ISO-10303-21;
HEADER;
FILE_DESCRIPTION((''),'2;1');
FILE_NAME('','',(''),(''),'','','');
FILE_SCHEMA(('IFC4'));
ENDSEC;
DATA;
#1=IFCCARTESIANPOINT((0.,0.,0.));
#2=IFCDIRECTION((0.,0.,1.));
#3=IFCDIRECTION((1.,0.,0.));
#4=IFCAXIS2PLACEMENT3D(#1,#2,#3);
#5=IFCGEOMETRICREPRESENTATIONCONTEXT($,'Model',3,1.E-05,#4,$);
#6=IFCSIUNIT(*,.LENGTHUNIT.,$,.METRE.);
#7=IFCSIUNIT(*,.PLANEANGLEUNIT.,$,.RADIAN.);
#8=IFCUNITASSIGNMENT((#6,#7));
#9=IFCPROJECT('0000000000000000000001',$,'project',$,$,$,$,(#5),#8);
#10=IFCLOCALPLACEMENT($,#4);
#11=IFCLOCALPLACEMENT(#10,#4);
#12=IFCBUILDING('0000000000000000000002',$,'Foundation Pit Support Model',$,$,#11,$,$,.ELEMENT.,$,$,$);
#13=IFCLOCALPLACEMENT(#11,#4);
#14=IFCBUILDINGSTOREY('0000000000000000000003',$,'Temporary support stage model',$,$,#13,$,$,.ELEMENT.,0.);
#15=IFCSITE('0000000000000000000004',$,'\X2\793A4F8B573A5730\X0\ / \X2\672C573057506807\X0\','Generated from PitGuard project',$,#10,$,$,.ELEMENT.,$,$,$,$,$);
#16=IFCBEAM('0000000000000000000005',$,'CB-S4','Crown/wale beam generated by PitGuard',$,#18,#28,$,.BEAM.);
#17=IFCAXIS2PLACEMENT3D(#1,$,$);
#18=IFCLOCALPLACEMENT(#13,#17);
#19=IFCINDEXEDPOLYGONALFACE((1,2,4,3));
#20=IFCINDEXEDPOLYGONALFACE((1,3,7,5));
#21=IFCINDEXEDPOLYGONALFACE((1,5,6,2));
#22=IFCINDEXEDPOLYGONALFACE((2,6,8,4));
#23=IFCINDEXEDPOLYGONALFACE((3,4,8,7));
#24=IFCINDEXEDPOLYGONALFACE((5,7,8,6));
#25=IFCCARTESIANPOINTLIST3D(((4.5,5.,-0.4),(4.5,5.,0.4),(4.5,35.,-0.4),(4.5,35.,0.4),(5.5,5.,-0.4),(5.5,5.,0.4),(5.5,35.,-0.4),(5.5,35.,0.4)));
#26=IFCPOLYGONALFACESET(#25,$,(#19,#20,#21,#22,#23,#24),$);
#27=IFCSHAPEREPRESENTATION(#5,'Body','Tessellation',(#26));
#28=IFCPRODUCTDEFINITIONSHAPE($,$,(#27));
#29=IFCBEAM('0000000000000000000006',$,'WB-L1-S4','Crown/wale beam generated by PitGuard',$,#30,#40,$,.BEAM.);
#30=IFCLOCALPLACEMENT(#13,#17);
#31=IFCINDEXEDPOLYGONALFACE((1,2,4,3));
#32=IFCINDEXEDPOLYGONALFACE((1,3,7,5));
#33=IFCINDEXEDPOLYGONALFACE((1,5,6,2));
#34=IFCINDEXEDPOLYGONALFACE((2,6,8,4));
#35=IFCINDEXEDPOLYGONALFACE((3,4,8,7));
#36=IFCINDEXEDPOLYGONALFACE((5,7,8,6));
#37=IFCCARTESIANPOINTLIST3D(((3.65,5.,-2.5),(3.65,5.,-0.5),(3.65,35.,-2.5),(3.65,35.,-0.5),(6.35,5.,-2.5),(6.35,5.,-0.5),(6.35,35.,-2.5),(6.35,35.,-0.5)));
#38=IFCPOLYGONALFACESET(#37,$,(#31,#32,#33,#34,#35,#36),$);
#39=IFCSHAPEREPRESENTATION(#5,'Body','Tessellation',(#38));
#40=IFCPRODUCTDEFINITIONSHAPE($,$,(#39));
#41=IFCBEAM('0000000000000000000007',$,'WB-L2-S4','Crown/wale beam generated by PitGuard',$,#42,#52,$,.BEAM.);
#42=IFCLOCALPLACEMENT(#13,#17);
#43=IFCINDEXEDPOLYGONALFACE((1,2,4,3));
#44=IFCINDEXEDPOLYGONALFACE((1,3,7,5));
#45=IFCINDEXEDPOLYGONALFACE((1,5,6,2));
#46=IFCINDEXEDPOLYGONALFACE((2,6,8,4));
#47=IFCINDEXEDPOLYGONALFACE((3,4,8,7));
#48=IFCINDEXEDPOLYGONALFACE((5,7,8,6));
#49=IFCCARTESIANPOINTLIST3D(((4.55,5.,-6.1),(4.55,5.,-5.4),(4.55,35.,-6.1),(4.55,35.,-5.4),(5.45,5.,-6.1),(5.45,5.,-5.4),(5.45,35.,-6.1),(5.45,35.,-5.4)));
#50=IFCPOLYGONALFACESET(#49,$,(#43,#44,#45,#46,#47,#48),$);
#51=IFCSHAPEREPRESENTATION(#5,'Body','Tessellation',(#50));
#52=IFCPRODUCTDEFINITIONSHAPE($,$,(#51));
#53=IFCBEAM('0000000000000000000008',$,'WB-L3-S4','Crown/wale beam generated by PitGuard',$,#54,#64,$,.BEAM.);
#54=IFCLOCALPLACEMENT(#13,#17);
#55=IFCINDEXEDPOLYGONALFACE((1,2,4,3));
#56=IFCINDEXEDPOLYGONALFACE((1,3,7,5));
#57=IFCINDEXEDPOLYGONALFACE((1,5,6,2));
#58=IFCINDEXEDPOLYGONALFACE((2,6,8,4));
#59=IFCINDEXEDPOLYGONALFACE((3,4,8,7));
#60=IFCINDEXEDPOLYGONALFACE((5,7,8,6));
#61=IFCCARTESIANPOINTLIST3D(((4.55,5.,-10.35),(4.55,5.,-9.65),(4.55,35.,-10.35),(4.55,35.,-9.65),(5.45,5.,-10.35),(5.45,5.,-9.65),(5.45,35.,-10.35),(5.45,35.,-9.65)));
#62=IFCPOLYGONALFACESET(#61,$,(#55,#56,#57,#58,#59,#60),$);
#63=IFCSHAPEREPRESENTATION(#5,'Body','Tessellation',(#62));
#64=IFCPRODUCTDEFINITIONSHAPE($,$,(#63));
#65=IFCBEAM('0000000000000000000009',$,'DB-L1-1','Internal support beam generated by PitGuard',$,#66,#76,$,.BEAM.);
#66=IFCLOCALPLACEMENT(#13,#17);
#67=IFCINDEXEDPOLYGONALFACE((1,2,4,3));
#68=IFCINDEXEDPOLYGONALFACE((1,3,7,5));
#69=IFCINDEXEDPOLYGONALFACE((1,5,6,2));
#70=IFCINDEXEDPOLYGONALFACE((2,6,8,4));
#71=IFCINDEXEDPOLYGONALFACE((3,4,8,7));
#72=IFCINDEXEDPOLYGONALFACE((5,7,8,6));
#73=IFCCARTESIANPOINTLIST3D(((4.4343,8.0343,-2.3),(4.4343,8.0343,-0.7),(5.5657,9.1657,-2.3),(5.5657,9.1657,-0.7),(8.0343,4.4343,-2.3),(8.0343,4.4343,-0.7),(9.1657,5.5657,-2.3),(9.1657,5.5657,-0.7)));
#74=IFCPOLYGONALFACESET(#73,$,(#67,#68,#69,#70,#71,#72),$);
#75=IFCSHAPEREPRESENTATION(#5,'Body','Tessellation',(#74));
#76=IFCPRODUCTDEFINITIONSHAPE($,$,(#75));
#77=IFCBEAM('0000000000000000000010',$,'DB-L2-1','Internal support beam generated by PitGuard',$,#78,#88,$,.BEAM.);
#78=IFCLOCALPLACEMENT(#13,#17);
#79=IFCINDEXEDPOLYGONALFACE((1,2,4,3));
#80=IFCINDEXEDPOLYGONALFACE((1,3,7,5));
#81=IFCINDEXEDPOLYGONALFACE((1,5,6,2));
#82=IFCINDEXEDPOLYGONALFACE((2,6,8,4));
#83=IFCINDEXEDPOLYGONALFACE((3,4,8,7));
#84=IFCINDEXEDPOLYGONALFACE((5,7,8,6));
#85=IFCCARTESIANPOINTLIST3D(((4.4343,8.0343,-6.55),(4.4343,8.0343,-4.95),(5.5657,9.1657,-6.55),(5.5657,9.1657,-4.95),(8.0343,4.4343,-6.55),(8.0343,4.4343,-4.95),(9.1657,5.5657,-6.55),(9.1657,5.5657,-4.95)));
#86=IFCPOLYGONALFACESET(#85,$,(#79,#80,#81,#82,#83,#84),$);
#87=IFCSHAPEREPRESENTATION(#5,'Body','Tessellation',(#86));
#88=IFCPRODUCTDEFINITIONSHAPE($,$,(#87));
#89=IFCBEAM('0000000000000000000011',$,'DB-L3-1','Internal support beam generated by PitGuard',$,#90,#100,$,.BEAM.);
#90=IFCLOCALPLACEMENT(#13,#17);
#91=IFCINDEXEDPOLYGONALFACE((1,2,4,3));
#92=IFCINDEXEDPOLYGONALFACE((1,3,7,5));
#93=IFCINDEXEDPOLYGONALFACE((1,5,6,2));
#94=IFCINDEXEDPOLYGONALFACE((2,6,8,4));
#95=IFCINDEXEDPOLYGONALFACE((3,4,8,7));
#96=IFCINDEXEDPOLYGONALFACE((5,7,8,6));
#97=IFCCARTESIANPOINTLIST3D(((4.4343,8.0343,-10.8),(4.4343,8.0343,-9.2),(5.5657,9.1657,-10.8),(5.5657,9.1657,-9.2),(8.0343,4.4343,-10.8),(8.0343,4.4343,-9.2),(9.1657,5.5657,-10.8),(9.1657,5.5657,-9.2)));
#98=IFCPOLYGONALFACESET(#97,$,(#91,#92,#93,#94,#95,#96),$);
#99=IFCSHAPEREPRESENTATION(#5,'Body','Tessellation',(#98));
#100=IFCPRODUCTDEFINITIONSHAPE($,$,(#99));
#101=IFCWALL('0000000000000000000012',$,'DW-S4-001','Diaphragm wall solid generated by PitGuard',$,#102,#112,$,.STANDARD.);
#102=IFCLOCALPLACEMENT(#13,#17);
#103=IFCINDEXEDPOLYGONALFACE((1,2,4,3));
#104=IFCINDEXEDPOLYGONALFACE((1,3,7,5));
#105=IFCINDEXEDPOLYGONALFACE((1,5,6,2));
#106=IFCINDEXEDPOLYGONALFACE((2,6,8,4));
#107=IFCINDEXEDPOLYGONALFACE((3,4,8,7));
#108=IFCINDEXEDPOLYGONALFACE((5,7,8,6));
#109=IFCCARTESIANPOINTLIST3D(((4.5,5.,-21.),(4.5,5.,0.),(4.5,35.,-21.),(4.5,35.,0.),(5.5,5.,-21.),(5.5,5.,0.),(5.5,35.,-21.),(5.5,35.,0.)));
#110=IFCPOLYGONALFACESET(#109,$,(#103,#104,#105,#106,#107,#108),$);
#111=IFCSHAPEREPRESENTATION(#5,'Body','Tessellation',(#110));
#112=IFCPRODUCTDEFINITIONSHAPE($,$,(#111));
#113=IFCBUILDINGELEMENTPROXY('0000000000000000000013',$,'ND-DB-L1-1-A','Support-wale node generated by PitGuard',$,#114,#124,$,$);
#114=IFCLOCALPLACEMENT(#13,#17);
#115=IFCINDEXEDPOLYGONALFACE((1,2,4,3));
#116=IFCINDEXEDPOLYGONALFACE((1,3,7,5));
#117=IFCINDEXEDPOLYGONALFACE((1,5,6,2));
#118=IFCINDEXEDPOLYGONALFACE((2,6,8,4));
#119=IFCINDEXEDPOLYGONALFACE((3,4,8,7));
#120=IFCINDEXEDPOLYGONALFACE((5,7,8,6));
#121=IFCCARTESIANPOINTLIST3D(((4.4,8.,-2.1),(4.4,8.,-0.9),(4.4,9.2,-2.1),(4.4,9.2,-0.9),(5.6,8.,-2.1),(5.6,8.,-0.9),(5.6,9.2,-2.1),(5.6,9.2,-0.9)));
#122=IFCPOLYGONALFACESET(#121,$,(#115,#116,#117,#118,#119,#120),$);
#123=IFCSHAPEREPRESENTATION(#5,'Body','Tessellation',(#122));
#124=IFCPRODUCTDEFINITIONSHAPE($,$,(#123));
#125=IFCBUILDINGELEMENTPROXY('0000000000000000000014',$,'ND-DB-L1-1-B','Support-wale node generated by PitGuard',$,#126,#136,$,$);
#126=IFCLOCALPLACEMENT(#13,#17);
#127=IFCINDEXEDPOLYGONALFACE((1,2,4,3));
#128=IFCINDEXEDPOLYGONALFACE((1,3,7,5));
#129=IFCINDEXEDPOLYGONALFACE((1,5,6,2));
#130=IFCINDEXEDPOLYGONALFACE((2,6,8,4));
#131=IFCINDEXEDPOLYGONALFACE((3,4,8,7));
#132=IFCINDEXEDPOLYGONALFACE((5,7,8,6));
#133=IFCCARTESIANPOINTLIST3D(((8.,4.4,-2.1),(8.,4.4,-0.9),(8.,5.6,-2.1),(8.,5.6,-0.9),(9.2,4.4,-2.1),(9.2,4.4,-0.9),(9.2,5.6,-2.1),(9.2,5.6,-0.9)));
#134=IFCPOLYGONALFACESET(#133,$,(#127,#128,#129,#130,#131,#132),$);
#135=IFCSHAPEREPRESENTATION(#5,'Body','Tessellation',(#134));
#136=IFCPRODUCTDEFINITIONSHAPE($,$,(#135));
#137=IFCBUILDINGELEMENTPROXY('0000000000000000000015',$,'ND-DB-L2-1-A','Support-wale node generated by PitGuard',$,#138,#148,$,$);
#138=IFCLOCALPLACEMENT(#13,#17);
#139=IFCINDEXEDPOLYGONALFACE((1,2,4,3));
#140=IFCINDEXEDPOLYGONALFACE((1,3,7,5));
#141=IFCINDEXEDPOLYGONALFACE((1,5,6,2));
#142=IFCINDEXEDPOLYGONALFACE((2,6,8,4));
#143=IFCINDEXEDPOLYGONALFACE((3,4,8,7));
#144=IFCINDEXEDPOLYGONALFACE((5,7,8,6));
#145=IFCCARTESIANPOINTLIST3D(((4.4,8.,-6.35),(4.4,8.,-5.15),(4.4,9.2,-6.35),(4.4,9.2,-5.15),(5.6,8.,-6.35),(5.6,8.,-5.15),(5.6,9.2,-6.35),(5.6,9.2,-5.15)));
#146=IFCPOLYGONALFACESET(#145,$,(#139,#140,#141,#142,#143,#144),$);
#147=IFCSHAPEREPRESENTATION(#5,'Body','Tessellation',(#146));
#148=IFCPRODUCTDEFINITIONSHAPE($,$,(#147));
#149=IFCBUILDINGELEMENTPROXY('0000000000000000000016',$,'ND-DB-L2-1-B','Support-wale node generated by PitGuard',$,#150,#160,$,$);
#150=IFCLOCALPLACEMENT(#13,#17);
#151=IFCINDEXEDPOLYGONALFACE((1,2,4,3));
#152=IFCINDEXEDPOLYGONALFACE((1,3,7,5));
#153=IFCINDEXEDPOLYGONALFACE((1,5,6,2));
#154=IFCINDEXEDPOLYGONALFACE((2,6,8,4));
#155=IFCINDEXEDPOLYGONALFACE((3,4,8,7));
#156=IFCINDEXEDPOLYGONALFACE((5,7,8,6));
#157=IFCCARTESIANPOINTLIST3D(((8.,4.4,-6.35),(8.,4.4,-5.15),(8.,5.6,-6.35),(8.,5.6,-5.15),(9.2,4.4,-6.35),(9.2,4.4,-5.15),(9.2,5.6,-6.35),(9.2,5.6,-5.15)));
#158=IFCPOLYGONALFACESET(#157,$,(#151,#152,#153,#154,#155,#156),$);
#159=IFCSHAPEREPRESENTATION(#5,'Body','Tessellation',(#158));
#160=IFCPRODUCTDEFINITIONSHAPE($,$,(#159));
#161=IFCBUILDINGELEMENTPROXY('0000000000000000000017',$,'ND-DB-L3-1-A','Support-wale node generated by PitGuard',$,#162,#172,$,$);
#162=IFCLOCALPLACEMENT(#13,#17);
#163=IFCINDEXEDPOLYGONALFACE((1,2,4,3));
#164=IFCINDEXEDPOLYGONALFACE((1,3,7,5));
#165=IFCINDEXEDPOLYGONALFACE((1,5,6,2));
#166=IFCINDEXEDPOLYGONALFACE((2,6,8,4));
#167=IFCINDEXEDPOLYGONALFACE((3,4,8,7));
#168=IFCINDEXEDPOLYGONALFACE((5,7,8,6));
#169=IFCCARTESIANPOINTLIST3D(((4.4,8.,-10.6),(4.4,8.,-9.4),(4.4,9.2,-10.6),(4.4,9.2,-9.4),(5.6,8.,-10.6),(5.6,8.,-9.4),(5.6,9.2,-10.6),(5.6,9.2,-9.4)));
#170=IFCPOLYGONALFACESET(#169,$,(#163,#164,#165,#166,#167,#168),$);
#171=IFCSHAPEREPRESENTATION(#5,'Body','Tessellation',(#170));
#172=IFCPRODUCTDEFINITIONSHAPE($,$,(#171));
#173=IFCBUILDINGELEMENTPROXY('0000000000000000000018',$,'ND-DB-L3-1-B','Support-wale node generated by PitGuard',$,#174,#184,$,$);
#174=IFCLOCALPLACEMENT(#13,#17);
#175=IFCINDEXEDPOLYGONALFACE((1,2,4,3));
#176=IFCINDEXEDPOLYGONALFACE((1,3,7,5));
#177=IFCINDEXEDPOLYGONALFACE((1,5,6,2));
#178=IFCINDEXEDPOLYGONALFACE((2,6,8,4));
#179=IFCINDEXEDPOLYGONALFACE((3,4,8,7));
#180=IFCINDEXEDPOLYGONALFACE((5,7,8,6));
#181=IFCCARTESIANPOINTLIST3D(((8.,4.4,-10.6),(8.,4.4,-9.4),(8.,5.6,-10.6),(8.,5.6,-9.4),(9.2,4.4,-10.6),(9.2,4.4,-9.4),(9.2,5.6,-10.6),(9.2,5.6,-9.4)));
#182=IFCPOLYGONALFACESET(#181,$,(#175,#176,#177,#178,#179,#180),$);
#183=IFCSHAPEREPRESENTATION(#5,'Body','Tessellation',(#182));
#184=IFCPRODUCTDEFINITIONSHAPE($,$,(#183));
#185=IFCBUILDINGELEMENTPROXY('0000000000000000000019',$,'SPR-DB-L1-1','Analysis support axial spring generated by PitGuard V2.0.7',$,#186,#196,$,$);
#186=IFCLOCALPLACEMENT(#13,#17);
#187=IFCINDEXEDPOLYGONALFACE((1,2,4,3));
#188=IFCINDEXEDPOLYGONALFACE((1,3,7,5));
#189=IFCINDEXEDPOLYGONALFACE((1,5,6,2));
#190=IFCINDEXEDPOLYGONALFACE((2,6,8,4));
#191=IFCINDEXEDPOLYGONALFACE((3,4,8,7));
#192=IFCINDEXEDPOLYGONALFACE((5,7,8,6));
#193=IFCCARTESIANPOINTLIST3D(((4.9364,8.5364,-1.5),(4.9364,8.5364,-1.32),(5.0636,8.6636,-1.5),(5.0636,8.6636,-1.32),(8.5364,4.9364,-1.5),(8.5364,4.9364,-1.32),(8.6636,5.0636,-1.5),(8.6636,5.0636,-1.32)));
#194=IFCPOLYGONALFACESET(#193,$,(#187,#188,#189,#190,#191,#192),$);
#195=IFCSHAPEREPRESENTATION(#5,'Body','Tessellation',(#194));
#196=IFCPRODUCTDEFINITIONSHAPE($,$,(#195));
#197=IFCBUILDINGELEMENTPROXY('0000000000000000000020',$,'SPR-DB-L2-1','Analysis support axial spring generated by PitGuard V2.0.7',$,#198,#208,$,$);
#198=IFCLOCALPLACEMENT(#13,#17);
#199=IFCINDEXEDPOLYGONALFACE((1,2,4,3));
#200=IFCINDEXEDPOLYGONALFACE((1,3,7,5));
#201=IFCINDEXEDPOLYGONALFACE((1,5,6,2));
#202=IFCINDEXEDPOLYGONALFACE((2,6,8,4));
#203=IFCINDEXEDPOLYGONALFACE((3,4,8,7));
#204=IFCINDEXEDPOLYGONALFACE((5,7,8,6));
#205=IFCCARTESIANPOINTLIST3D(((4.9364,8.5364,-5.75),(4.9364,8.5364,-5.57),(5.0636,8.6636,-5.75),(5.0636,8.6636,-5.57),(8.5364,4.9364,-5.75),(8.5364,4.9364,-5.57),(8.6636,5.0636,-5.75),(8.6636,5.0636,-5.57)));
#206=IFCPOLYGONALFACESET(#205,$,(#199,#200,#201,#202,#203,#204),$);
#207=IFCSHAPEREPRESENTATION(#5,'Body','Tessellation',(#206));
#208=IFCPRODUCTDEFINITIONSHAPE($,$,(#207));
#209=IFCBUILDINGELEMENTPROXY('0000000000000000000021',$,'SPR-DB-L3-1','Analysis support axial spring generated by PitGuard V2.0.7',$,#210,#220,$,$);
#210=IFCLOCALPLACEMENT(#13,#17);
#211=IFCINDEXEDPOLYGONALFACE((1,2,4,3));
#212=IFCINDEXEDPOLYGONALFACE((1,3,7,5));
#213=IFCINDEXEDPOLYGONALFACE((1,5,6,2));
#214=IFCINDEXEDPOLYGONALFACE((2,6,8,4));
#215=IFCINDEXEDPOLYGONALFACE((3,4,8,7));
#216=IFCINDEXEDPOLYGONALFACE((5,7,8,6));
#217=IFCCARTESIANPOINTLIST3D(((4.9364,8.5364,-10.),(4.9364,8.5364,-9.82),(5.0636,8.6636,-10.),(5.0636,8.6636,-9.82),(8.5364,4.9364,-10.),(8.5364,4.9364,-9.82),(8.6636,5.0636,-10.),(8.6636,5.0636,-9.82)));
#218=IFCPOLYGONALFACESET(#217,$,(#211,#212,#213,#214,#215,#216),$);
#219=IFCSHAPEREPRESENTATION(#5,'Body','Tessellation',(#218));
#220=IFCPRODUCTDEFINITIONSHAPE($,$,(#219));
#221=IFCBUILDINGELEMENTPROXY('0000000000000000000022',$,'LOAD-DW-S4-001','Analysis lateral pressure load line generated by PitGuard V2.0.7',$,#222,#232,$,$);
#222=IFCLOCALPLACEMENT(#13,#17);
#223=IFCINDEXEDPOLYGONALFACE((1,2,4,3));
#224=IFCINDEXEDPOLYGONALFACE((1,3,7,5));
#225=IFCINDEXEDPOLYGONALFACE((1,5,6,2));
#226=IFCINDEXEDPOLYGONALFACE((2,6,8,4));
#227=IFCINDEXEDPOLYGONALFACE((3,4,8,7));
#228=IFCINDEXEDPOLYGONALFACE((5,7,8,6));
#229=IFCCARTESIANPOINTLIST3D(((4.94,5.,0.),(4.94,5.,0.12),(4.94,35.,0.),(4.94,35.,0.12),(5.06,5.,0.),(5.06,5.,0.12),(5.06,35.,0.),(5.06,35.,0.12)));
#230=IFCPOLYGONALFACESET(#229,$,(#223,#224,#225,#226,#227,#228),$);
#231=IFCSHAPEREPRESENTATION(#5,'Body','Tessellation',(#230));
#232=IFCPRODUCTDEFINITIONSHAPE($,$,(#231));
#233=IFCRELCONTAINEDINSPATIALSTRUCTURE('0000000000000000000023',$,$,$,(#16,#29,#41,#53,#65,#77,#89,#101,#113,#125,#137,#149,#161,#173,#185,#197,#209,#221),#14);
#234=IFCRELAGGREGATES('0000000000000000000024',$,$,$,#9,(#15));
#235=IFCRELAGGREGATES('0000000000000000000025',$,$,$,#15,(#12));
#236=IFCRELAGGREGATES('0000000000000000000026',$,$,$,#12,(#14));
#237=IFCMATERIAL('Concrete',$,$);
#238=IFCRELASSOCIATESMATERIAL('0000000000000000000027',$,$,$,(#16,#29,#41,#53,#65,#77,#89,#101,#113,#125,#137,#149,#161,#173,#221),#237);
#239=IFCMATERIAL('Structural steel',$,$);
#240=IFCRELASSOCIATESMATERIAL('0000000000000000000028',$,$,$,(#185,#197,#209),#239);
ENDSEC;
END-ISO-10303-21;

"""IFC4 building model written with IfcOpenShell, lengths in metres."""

from ifc_helpers import new_model, si_unit, frame, origin_with_axes, origin_2d, place, context, project, spatial, rectangle, extrude, material, element, save


model = new_model("IFC4")

# Units and contexts
model_context = context("Model", 3, precision=1e-05, world=origin_with_axes())
ifc_project = project(units=[si_unit("LENGTHUNIT", "METRE"), si_unit("PLANEANGLEUNIT", "RADIAN")], contexts=[model_context])

# Site, building, storey
site_placement = place(None, origin_with_axes())
site = spatial("IfcSite", under=ifc_project, at=site_placement, Name="示例场地 / 本地坐标", Description="Generated from PitGuard project", CompositionType="ELEMENT")
building_placement = place(site_placement, origin_with_axes())
building = spatial("IfcBuilding", under=site, at=building_placement, Name="Foundation Pit Support Model", CompositionType="ELEMENT")
storey_placement = place(building_placement, origin_with_axes())
storey = spatial("IfcBuildingStorey", under=building, at=storey_placement, Name="Temporary support stage model", CompositionType="ELEMENT", Elevation=0.0)

# Beams
ifc_material_1 = material(Name="Concrete")
beam_1_placement = place(storey_placement, frame((5.0, 20.0, -0.4), z_axis=(0.0, 0.0, 1.0), x_axis=(0.0, -1.0, 0.0)))
element("IfcBeam", 1, at=beam_1_placement, inside=storey, material=ifc_material_1, Name="CB-S4", Description="Crown/wale beam generated by PitGuard", PredefinedType="BEAM", context=model_context, shape_type="SweptSolid", body=[
    extrude(rectangle(XDim=30.0, YDim=1.0, at=origin_2d()), origin_with_axes(), (0.0, 0.0, 1.0), 0.8),
])
beam_2_placement = place(storey_placement, frame((5.0, 20.0, -2.5), z_axis=(0.0, 0.0, 1.0), x_axis=(0.0, -1.0, 0.0)))
element("IfcBeam", 2, at=beam_2_placement, inside=storey, material=ifc_material_1, Name="WB-L1-S4", Description="Crown/wale beam generated by PitGuard", PredefinedType="BEAM", context=model_context, shape_type="SweptSolid", body=[
    extrude(rectangle(XDim=30.0, YDim=2.7, at=origin_2d()), origin_with_axes(), (0.0, 0.0, 1.0), 2.0),
])
for number, where, z_axis, x_axis, name in (
    (3, (5.0, 20.0, -6.1), (0.0, 0.0, 1.0), (0.0, -1.0, 0.0), "WB-L2-S4"),
    (4, (5.0, 20.0, -10.35), (0.0, 0.0, 1.0), (0.0, -1.0, 0.0), "WB-L3-S4"),
):
    element("IfcBeam", number, at=place(storey_placement, frame(where, z_axis=z_axis, x_axis=x_axis)), inside=storey, material=ifc_material_1, Name=name, Description="Crown/wale beam generated by PitGuard", PredefinedType="BEAM", context=model_context, shape_type="SweptSolid", body=[
        extrude(rectangle(XDim=30.0, YDim=0.9, at=origin_2d()), origin_with_axes(), (0.0, 0.0, 1.0), 0.7),
    ])
for number, where, z_axis, x_axis, name in (
    (5, (6.8, 6.8, -2.3), (0.0, 0.0, 1.0), (0.707107, -0.707107, 0.0), "DB-L1-1"),
    (6, (6.8, 6.8, -6.55), (0.0, 0.0, 1.0), (0.707107, -0.707107, 0.0), "DB-L2-1"),
    (7, (6.8, 6.8, -10.8), (0.0, 0.0, 1.0), (0.707107, -0.707107, 0.0), "DB-L3-1"),
):
    element("IfcBeam", number, at=place(storey_placement, frame(where, z_axis=z_axis, x_axis=x_axis)), inside=storey, material=ifc_material_1, Name=name, Description="Internal support beam generated by PitGuard", PredefinedType="BEAM", context=model_context, shape_type="SweptSolid", body=[
        extrude(rectangle(XDim=5.0912, YDim=1.6, at=origin_2d()), origin_with_axes(), (0.0, 0.0, 1.0), 1.6),
    ])

# Wall
wall_placement = place(storey_placement, frame((5.0, 20.0, -21.0), z_axis=(0.0, 0.0, 1.0), x_axis=(0.0, -1.0, 0.0)))
element("IfcWall", 8, at=wall_placement, inside=storey, material=ifc_material_1, Name="DW-S4-001", Description="Diaphragm wall solid generated by PitGuard", PredefinedType="STANDARD", context=model_context, shape_type="SweptSolid", body=[
    extrude(rectangle(XDim=30.0, YDim=1.0, at=origin_2d()), origin_with_axes(), (0.0, 0.0, 1.0), 21.0),
])

# Building element proxies
for number, where, z_axis, x_axis, name in (
    (9, (5.0, 8.6, -2.1), (0.0, 0.0, 1.0), (1.0, 0.0, 0.0), "ND-DB-L1-1-A"),
    (10, (8.6, 5.0, -2.1), (0.0, 0.0, 1.0), (1.0, 0.0, 0.0), "ND-DB-L1-1-B"),
    (11, (5.0, 8.6, -6.35), (0.0, 0.0, 1.0), (1.0, 0.0, 0.0), "ND-DB-L2-1-A"),
    (12, (8.6, 5.0, -6.35), (0.0, 0.0, 1.0), (1.0, 0.0, 0.0), "ND-DB-L2-1-B"),
    (13, (5.0, 8.6, -10.6), (0.0, 0.0, 1.0), (1.0, 0.0, 0.0), "ND-DB-L3-1-A"),
    (14, (8.6, 5.0, -10.6), (0.0, 0.0, 1.0), (1.0, 0.0, 0.0), "ND-DB-L3-1-B"),
):
    element("IfcBuildingElementProxy", number, at=place(storey_placement, frame(where, z_axis=z_axis, x_axis=x_axis)), inside=storey, material=ifc_material_1, Name=name, Description="Support-wale node generated by PitGuard", context=model_context, shape_type="SweptSolid", body=[
        extrude(rectangle(XDim=1.2, YDim=1.2, at=origin_2d()), origin_with_axes(), (0.0, 0.0, 1.0), 1.2),
    ])
ifc_material_2 = material(Name="Structural steel")
for number, where, z_axis, x_axis, name in (
    (15, (6.8, 6.8, -1.5), (0.0, 0.0, 1.0), (0.707107, -0.707107, 0.0), "SPR-DB-L1-1"),
    (16, (6.8, 6.8, -5.75), (0.0, 0.0, 1.0), (0.707107, -0.707107, 0.0), "SPR-DB-L2-1"),
    (17, (6.8, 6.8, -10.0), (0.0, 0.0, 1.0), (0.707107, -0.707107, 0.0), "SPR-DB-L3-1"),
):
    element("IfcBuildingElementProxy", number, at=place(storey_placement, frame(where, z_axis=z_axis, x_axis=x_axis)), inside=storey, material=ifc_material_2, Name=name, Description="Analysis support axial spring generated by PitGuard V2.0.7", context=model_context, shape_type="SweptSolid", body=[
        extrude(rectangle(XDim=5.0912, YDim=0.18, at=origin_2d()), origin_with_axes(), (0.0, 0.0, 1.0), 0.18),
    ])
proxy_placement = place(storey_placement, frame((5.0, 20.0, 0.0), z_axis=(0.0, 0.0, 1.0), x_axis=(0.0, -1.0, 0.0)))
element("IfcBuildingElementProxy", 18, at=proxy_placement, inside=storey, material=ifc_material_1, Name="LOAD-DW-S4-001", Description="Analysis lateral pressure load line generated by PitGuard V2.0.7", context=model_context, shape_type="SweptSolid", body=[
    extrude(rectangle(XDim=30.0, YDim=0.12, at=origin_2d()), origin_with_axes(), (0.0, 0.0, 1.0), 0.12),
])

save(model, "model.ifc")
